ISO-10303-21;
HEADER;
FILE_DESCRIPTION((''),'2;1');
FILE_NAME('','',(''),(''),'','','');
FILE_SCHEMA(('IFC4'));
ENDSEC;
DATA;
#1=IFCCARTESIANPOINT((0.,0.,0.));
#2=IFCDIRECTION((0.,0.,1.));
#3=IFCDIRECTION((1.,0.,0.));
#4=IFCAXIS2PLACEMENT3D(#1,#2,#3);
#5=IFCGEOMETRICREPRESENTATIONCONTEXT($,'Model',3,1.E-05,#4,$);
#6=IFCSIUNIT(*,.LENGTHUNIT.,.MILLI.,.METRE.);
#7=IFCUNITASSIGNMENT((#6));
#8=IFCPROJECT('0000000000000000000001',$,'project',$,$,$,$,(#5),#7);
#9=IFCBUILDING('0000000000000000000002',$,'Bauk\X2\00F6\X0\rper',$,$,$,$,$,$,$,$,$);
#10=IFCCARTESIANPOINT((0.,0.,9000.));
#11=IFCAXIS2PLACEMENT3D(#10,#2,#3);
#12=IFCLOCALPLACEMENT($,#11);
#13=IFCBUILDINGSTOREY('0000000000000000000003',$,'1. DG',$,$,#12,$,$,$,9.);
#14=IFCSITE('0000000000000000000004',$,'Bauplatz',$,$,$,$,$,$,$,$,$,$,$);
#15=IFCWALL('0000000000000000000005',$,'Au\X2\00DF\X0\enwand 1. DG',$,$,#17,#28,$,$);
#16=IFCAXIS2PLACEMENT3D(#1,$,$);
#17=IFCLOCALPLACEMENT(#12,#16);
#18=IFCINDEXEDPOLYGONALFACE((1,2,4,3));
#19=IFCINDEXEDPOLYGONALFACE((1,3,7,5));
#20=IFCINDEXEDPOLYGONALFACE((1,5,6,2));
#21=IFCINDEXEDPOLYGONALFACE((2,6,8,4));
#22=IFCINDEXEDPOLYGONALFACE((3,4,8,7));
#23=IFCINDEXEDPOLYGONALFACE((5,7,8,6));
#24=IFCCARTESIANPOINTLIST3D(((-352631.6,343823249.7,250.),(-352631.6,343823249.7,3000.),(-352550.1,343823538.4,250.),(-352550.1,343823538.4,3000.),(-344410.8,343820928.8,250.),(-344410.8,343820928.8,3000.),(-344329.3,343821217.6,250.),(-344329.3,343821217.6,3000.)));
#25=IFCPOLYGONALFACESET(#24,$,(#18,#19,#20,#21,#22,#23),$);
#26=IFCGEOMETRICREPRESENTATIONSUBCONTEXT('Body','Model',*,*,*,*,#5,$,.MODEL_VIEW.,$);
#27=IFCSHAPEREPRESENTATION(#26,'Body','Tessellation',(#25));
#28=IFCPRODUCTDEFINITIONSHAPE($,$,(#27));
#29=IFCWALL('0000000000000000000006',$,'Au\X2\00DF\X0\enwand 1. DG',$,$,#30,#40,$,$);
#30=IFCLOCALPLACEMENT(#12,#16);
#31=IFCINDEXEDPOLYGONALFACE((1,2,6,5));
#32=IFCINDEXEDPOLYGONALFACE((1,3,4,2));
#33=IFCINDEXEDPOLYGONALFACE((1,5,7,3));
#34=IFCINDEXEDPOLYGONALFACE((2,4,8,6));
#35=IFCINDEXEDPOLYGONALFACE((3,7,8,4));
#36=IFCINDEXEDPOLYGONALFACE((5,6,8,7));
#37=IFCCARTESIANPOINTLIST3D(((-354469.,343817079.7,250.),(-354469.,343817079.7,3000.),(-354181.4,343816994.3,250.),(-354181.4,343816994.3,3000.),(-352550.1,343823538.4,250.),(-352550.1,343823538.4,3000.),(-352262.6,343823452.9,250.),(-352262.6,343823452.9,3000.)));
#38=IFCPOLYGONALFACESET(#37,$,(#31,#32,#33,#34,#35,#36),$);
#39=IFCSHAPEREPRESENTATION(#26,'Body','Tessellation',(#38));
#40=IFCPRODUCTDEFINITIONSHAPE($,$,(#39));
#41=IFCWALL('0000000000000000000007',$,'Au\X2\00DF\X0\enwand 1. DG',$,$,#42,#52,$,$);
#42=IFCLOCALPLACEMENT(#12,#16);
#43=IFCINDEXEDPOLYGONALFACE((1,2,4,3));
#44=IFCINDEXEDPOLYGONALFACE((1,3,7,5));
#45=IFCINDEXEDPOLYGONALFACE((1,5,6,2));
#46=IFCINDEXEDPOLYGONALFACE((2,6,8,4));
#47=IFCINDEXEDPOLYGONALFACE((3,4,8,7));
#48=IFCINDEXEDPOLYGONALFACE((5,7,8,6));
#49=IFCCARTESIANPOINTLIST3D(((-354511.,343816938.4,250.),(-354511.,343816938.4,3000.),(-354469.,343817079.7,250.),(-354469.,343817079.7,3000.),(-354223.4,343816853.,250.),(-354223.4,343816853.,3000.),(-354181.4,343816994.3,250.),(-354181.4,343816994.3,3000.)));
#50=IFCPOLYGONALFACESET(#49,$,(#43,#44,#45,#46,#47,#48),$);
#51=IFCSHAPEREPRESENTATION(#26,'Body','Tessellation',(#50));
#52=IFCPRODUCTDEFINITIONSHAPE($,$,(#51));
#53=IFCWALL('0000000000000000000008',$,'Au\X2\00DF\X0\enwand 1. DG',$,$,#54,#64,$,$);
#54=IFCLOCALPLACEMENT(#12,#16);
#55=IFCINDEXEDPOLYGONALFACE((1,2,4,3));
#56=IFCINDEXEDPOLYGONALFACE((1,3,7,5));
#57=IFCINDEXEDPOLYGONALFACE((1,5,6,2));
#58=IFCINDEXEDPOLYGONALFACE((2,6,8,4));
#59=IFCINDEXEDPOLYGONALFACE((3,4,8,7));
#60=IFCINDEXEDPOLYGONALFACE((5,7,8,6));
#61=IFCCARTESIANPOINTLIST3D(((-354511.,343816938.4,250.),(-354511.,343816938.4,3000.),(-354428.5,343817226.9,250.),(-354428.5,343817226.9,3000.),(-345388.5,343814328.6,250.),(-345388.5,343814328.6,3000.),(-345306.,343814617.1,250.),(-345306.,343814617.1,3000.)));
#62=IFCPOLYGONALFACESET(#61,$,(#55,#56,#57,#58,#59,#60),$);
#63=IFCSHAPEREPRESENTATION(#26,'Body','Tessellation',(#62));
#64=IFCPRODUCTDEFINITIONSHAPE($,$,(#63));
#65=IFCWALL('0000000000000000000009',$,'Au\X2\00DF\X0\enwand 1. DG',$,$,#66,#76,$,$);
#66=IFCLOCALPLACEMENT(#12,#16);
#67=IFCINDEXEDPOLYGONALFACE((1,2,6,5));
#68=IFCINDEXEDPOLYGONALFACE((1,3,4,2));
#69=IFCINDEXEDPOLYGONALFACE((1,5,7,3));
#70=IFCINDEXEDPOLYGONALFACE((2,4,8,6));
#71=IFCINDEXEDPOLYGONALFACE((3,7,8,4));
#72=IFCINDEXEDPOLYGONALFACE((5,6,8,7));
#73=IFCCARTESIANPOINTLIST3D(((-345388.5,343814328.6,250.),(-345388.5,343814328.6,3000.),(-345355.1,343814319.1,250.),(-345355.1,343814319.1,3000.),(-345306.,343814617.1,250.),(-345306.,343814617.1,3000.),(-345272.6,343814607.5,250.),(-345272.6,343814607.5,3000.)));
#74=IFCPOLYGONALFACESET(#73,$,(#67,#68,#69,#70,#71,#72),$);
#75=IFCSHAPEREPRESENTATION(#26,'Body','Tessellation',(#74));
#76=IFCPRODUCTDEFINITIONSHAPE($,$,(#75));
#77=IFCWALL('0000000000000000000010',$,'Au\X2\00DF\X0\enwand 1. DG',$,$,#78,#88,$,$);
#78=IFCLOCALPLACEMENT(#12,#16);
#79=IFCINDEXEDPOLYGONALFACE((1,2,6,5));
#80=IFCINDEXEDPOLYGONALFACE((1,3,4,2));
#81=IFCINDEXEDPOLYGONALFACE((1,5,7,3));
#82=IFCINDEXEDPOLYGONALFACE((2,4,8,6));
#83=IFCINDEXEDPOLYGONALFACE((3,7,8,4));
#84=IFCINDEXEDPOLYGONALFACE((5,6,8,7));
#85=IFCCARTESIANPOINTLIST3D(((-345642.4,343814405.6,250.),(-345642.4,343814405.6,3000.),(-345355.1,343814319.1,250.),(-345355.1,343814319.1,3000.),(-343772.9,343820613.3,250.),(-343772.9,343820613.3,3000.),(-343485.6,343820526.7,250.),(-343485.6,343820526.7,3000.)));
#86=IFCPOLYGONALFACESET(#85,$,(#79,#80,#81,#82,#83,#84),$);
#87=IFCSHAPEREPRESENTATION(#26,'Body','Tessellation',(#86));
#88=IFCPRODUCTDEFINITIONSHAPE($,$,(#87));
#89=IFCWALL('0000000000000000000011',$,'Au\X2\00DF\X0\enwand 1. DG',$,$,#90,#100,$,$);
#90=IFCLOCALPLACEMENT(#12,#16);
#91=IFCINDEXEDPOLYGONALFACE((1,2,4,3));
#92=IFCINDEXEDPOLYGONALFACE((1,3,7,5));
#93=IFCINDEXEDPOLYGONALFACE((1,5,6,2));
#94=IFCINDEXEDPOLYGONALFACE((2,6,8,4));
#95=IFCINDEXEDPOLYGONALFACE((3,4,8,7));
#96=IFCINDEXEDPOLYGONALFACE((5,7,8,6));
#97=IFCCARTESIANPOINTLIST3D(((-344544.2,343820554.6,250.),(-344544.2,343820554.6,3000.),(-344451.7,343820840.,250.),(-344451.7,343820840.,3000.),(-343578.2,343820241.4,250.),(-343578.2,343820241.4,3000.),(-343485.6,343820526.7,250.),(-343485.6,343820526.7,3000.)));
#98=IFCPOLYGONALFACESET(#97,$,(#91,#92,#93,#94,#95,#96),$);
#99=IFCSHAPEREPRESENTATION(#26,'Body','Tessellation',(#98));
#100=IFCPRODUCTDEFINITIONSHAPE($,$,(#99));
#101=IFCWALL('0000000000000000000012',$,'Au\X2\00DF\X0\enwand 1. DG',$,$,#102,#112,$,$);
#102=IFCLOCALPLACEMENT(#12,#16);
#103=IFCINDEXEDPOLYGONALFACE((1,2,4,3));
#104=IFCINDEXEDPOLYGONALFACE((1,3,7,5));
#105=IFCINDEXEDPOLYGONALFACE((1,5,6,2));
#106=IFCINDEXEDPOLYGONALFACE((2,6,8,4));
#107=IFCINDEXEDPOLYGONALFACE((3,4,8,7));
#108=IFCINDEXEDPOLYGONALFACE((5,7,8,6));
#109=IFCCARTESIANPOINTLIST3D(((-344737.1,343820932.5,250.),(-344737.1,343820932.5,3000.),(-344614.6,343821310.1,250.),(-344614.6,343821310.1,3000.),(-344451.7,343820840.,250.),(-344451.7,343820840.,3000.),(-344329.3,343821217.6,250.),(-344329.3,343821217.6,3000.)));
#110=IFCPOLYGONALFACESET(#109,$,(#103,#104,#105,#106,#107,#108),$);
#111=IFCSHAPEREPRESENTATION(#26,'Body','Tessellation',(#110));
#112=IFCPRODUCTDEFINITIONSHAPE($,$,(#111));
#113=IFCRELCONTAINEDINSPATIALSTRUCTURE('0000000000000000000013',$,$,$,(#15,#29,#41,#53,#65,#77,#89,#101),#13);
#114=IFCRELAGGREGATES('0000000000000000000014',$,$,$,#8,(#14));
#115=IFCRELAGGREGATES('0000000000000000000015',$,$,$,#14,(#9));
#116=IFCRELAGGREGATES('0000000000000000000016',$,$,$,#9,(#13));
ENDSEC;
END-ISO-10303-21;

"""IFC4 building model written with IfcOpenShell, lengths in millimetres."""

from ifc_helpers import new_model, si_unit, frame, origin_with_axes, place, context, subcontext, project, spatial, indexed_curve, outline, extrude, element, save


model = new_model("IFC4")

# Units and contexts
model_context = context("Model", 3, precision=1e-05, world=origin_with_axes())
body_context = subcontext(model_context, "Body", "Model", "MODEL_VIEW")
ifc_project = project(units=[si_unit("LENGTHUNIT", "METRE", prefix="MILLI")], contexts=[model_context])

# Site, building, storey
site = spatial("IfcSite", under=ifc_project, Name="Bauplatz")
building = spatial("IfcBuilding", under=site, Name="Baukörper")
storey_placement = place(None, frame((0.0, 0.0, 9000.0), z_axis=(0.0, 0.0, 1.0), x_axis=(1.0, 0.0, 0.0)))
storey = spatial("IfcBuildingStorey", under=building, at=storey_placement, Name="1. DG", Elevation=9.0)

# Walls
wall_1_placement = place(storey_placement, frame((-344329.3, 343821217.6, 250.0), z_axis=(0.0, 0.0, 1.0), x_axis=(-0.962385, 0.271691, 0.0)))
element("IfcWall", 1, at=wall_1_placement, inside=storey, Name="Außenwand 1. DG", context=body_context, shape_type="SweptSolid", body=[
    extrude(outline(indexed_curve([(0.0, 0.0), (0.0, 300.0), (8542.2, 300.0), (8542.2, 0.0), (0.0, 0.0)], self_intersect=False)), origin_with_axes(), (0.0, 0.0, 1.0), 2750.0),
])
wall_2_placement = place(storey_placement, frame((-352550.1, 343823538.4, 250.0), z_axis=(0.0, 0.0, 1.0), x_axis=(-0.284796, -0.958588, 0.0)))
element("IfcWall", 2, at=wall_2_placement, inside=storey, Name="Außenwand 1. DG", context=body_context, shape_type="SweptSolid", body=[
    extrude(outline(indexed_curve([(0.0, 0.0), (0.0, 300.0), (6737.7, 300.0), (6737.7, 0.0), (0.0, 0.0)], self_intersect=False)), origin_with_axes(), (0.0, 0.0, 1.0), 2750.0),
])
wall_3_placement = place(storey_placement, frame((-354469.0, 343817079.7, 250.0), z_axis=(0.0, 0.0, 1.0), x_axis=(-0.284796, -0.958588, 0.0)))
element("IfcWall", 3, at=wall_3_placement, inside=storey, Name="Außenwand 1. DG", context=body_context, shape_type="SweptSolid", body=[
    extrude(outline(indexed_curve([(0.0, 0.0), (0.0, 300.0), (147.4, 300.0), (147.4, 0.0), (0.0, 0.0)], self_intersect=False)), origin_with_axes(), (0.0, 0.0, 1.0), 2750.0),
])
wall_4_placement = place(storey_placement, frame((-354511.0, 343816938.4, 250.0), z_axis=(0.0, 0.0, 1.0), x_axis=(0.96143, -0.275051, 0.0)))
element("IfcWall", 4, at=wall_4_placement, inside=storey, Name="Außenwand 1. DG", context=body_context, shape_type="SweptSolid", body=[
    extrude(outline(indexed_curve([(0.0, 0.0), (0.0, 300.0), (9488.5, 300.0), (9488.5, 0.0), (0.0, 0.0)], self_intersect=False)), origin_with_axes(), (0.0, 0.0, 1.0), 2750.0),
])
wall_5_placement = place(storey_placement, frame((-345388.5, 343814328.6, 250.0), z_axis=(0.0, 0.0, 1.0), x_axis=(0.96143, -0.275051, 0.0)))
element("IfcWall", 5, at=wall_5_placement, inside=storey, Name="Außenwand 1. DG", context=body_context, shape_type="SweptSolid", body=[
    extrude(outline(indexed_curve([(0.0, 0.0), (0.0, 300.0), (34.7, 300.0), (34.7, 0.0), (0.0, 0.0)], self_intersect=False)), origin_with_axes(), (0.0, 0.0, 1.0), 2750.0),
])
wall_6_placement = place(storey_placement, frame((-345355.1, 343814319.1, 250.0), z_axis=(0.0, 0.0, 1.0), x_axis=(0.288362, 0.957521, 0.0)))
element("IfcWall", 6, at=wall_6_placement, inside=storey, Name="Außenwand 1. DG", context=body_context, shape_type="SweptSolid", body=[
    extrude(outline(indexed_curve([(0.0, 0.0), (0.0, 300.0), (6483.1, 300.0), (6483.1, 0.0), (0.0, 0.0)], self_intersect=False)), origin_with_axes(), (0.0, 0.0, 1.0), 2750.0),
])
wall_7_placement = place(storey_placement, frame((-343485.6, 343820526.7, 250.0), z_axis=(0.0, 0.0, 1.0), x_axis=(-0.951248, 0.308429, 0.0)))
element("IfcWall", 7, at=wall_7_placement, inside=storey, Name="Außenwand 1. DG", context=body_context, shape_type="SweptSolid", body=[
    extrude(outline(indexed_curve([(0.0, 0.0), (0.0, 300.0), (1015.6, 300.0), (1015.6, 0.0), (0.0, 0.0)], self_intersect=False)), origin_with_axes(), (0.0, 0.0, 1.0), 2750.0),
])
wall_8_placement = place(storey_placement, frame((-344451.7, 343820840.0, 250.0), z_axis=(0.0, 0.0, 1.0), x_axis=(0.308429, 0.951248, 0.0)))
element("IfcWall", 8, at=wall_8_placement, inside=storey, Name="Außenwand 1. DG", context=body_context, shape_type="SweptSolid", body=[
    extrude(outline(indexed_curve([(0.0, 0.0), (0.0, 300.0), (396.9, 300.0), (396.9, 0.0), (0.0, 0.0)], self_intersect=False)), origin_with_axes(), (0.0, 0.0, 1.0), 2750.0),
])

save(model, "model.ifc")
